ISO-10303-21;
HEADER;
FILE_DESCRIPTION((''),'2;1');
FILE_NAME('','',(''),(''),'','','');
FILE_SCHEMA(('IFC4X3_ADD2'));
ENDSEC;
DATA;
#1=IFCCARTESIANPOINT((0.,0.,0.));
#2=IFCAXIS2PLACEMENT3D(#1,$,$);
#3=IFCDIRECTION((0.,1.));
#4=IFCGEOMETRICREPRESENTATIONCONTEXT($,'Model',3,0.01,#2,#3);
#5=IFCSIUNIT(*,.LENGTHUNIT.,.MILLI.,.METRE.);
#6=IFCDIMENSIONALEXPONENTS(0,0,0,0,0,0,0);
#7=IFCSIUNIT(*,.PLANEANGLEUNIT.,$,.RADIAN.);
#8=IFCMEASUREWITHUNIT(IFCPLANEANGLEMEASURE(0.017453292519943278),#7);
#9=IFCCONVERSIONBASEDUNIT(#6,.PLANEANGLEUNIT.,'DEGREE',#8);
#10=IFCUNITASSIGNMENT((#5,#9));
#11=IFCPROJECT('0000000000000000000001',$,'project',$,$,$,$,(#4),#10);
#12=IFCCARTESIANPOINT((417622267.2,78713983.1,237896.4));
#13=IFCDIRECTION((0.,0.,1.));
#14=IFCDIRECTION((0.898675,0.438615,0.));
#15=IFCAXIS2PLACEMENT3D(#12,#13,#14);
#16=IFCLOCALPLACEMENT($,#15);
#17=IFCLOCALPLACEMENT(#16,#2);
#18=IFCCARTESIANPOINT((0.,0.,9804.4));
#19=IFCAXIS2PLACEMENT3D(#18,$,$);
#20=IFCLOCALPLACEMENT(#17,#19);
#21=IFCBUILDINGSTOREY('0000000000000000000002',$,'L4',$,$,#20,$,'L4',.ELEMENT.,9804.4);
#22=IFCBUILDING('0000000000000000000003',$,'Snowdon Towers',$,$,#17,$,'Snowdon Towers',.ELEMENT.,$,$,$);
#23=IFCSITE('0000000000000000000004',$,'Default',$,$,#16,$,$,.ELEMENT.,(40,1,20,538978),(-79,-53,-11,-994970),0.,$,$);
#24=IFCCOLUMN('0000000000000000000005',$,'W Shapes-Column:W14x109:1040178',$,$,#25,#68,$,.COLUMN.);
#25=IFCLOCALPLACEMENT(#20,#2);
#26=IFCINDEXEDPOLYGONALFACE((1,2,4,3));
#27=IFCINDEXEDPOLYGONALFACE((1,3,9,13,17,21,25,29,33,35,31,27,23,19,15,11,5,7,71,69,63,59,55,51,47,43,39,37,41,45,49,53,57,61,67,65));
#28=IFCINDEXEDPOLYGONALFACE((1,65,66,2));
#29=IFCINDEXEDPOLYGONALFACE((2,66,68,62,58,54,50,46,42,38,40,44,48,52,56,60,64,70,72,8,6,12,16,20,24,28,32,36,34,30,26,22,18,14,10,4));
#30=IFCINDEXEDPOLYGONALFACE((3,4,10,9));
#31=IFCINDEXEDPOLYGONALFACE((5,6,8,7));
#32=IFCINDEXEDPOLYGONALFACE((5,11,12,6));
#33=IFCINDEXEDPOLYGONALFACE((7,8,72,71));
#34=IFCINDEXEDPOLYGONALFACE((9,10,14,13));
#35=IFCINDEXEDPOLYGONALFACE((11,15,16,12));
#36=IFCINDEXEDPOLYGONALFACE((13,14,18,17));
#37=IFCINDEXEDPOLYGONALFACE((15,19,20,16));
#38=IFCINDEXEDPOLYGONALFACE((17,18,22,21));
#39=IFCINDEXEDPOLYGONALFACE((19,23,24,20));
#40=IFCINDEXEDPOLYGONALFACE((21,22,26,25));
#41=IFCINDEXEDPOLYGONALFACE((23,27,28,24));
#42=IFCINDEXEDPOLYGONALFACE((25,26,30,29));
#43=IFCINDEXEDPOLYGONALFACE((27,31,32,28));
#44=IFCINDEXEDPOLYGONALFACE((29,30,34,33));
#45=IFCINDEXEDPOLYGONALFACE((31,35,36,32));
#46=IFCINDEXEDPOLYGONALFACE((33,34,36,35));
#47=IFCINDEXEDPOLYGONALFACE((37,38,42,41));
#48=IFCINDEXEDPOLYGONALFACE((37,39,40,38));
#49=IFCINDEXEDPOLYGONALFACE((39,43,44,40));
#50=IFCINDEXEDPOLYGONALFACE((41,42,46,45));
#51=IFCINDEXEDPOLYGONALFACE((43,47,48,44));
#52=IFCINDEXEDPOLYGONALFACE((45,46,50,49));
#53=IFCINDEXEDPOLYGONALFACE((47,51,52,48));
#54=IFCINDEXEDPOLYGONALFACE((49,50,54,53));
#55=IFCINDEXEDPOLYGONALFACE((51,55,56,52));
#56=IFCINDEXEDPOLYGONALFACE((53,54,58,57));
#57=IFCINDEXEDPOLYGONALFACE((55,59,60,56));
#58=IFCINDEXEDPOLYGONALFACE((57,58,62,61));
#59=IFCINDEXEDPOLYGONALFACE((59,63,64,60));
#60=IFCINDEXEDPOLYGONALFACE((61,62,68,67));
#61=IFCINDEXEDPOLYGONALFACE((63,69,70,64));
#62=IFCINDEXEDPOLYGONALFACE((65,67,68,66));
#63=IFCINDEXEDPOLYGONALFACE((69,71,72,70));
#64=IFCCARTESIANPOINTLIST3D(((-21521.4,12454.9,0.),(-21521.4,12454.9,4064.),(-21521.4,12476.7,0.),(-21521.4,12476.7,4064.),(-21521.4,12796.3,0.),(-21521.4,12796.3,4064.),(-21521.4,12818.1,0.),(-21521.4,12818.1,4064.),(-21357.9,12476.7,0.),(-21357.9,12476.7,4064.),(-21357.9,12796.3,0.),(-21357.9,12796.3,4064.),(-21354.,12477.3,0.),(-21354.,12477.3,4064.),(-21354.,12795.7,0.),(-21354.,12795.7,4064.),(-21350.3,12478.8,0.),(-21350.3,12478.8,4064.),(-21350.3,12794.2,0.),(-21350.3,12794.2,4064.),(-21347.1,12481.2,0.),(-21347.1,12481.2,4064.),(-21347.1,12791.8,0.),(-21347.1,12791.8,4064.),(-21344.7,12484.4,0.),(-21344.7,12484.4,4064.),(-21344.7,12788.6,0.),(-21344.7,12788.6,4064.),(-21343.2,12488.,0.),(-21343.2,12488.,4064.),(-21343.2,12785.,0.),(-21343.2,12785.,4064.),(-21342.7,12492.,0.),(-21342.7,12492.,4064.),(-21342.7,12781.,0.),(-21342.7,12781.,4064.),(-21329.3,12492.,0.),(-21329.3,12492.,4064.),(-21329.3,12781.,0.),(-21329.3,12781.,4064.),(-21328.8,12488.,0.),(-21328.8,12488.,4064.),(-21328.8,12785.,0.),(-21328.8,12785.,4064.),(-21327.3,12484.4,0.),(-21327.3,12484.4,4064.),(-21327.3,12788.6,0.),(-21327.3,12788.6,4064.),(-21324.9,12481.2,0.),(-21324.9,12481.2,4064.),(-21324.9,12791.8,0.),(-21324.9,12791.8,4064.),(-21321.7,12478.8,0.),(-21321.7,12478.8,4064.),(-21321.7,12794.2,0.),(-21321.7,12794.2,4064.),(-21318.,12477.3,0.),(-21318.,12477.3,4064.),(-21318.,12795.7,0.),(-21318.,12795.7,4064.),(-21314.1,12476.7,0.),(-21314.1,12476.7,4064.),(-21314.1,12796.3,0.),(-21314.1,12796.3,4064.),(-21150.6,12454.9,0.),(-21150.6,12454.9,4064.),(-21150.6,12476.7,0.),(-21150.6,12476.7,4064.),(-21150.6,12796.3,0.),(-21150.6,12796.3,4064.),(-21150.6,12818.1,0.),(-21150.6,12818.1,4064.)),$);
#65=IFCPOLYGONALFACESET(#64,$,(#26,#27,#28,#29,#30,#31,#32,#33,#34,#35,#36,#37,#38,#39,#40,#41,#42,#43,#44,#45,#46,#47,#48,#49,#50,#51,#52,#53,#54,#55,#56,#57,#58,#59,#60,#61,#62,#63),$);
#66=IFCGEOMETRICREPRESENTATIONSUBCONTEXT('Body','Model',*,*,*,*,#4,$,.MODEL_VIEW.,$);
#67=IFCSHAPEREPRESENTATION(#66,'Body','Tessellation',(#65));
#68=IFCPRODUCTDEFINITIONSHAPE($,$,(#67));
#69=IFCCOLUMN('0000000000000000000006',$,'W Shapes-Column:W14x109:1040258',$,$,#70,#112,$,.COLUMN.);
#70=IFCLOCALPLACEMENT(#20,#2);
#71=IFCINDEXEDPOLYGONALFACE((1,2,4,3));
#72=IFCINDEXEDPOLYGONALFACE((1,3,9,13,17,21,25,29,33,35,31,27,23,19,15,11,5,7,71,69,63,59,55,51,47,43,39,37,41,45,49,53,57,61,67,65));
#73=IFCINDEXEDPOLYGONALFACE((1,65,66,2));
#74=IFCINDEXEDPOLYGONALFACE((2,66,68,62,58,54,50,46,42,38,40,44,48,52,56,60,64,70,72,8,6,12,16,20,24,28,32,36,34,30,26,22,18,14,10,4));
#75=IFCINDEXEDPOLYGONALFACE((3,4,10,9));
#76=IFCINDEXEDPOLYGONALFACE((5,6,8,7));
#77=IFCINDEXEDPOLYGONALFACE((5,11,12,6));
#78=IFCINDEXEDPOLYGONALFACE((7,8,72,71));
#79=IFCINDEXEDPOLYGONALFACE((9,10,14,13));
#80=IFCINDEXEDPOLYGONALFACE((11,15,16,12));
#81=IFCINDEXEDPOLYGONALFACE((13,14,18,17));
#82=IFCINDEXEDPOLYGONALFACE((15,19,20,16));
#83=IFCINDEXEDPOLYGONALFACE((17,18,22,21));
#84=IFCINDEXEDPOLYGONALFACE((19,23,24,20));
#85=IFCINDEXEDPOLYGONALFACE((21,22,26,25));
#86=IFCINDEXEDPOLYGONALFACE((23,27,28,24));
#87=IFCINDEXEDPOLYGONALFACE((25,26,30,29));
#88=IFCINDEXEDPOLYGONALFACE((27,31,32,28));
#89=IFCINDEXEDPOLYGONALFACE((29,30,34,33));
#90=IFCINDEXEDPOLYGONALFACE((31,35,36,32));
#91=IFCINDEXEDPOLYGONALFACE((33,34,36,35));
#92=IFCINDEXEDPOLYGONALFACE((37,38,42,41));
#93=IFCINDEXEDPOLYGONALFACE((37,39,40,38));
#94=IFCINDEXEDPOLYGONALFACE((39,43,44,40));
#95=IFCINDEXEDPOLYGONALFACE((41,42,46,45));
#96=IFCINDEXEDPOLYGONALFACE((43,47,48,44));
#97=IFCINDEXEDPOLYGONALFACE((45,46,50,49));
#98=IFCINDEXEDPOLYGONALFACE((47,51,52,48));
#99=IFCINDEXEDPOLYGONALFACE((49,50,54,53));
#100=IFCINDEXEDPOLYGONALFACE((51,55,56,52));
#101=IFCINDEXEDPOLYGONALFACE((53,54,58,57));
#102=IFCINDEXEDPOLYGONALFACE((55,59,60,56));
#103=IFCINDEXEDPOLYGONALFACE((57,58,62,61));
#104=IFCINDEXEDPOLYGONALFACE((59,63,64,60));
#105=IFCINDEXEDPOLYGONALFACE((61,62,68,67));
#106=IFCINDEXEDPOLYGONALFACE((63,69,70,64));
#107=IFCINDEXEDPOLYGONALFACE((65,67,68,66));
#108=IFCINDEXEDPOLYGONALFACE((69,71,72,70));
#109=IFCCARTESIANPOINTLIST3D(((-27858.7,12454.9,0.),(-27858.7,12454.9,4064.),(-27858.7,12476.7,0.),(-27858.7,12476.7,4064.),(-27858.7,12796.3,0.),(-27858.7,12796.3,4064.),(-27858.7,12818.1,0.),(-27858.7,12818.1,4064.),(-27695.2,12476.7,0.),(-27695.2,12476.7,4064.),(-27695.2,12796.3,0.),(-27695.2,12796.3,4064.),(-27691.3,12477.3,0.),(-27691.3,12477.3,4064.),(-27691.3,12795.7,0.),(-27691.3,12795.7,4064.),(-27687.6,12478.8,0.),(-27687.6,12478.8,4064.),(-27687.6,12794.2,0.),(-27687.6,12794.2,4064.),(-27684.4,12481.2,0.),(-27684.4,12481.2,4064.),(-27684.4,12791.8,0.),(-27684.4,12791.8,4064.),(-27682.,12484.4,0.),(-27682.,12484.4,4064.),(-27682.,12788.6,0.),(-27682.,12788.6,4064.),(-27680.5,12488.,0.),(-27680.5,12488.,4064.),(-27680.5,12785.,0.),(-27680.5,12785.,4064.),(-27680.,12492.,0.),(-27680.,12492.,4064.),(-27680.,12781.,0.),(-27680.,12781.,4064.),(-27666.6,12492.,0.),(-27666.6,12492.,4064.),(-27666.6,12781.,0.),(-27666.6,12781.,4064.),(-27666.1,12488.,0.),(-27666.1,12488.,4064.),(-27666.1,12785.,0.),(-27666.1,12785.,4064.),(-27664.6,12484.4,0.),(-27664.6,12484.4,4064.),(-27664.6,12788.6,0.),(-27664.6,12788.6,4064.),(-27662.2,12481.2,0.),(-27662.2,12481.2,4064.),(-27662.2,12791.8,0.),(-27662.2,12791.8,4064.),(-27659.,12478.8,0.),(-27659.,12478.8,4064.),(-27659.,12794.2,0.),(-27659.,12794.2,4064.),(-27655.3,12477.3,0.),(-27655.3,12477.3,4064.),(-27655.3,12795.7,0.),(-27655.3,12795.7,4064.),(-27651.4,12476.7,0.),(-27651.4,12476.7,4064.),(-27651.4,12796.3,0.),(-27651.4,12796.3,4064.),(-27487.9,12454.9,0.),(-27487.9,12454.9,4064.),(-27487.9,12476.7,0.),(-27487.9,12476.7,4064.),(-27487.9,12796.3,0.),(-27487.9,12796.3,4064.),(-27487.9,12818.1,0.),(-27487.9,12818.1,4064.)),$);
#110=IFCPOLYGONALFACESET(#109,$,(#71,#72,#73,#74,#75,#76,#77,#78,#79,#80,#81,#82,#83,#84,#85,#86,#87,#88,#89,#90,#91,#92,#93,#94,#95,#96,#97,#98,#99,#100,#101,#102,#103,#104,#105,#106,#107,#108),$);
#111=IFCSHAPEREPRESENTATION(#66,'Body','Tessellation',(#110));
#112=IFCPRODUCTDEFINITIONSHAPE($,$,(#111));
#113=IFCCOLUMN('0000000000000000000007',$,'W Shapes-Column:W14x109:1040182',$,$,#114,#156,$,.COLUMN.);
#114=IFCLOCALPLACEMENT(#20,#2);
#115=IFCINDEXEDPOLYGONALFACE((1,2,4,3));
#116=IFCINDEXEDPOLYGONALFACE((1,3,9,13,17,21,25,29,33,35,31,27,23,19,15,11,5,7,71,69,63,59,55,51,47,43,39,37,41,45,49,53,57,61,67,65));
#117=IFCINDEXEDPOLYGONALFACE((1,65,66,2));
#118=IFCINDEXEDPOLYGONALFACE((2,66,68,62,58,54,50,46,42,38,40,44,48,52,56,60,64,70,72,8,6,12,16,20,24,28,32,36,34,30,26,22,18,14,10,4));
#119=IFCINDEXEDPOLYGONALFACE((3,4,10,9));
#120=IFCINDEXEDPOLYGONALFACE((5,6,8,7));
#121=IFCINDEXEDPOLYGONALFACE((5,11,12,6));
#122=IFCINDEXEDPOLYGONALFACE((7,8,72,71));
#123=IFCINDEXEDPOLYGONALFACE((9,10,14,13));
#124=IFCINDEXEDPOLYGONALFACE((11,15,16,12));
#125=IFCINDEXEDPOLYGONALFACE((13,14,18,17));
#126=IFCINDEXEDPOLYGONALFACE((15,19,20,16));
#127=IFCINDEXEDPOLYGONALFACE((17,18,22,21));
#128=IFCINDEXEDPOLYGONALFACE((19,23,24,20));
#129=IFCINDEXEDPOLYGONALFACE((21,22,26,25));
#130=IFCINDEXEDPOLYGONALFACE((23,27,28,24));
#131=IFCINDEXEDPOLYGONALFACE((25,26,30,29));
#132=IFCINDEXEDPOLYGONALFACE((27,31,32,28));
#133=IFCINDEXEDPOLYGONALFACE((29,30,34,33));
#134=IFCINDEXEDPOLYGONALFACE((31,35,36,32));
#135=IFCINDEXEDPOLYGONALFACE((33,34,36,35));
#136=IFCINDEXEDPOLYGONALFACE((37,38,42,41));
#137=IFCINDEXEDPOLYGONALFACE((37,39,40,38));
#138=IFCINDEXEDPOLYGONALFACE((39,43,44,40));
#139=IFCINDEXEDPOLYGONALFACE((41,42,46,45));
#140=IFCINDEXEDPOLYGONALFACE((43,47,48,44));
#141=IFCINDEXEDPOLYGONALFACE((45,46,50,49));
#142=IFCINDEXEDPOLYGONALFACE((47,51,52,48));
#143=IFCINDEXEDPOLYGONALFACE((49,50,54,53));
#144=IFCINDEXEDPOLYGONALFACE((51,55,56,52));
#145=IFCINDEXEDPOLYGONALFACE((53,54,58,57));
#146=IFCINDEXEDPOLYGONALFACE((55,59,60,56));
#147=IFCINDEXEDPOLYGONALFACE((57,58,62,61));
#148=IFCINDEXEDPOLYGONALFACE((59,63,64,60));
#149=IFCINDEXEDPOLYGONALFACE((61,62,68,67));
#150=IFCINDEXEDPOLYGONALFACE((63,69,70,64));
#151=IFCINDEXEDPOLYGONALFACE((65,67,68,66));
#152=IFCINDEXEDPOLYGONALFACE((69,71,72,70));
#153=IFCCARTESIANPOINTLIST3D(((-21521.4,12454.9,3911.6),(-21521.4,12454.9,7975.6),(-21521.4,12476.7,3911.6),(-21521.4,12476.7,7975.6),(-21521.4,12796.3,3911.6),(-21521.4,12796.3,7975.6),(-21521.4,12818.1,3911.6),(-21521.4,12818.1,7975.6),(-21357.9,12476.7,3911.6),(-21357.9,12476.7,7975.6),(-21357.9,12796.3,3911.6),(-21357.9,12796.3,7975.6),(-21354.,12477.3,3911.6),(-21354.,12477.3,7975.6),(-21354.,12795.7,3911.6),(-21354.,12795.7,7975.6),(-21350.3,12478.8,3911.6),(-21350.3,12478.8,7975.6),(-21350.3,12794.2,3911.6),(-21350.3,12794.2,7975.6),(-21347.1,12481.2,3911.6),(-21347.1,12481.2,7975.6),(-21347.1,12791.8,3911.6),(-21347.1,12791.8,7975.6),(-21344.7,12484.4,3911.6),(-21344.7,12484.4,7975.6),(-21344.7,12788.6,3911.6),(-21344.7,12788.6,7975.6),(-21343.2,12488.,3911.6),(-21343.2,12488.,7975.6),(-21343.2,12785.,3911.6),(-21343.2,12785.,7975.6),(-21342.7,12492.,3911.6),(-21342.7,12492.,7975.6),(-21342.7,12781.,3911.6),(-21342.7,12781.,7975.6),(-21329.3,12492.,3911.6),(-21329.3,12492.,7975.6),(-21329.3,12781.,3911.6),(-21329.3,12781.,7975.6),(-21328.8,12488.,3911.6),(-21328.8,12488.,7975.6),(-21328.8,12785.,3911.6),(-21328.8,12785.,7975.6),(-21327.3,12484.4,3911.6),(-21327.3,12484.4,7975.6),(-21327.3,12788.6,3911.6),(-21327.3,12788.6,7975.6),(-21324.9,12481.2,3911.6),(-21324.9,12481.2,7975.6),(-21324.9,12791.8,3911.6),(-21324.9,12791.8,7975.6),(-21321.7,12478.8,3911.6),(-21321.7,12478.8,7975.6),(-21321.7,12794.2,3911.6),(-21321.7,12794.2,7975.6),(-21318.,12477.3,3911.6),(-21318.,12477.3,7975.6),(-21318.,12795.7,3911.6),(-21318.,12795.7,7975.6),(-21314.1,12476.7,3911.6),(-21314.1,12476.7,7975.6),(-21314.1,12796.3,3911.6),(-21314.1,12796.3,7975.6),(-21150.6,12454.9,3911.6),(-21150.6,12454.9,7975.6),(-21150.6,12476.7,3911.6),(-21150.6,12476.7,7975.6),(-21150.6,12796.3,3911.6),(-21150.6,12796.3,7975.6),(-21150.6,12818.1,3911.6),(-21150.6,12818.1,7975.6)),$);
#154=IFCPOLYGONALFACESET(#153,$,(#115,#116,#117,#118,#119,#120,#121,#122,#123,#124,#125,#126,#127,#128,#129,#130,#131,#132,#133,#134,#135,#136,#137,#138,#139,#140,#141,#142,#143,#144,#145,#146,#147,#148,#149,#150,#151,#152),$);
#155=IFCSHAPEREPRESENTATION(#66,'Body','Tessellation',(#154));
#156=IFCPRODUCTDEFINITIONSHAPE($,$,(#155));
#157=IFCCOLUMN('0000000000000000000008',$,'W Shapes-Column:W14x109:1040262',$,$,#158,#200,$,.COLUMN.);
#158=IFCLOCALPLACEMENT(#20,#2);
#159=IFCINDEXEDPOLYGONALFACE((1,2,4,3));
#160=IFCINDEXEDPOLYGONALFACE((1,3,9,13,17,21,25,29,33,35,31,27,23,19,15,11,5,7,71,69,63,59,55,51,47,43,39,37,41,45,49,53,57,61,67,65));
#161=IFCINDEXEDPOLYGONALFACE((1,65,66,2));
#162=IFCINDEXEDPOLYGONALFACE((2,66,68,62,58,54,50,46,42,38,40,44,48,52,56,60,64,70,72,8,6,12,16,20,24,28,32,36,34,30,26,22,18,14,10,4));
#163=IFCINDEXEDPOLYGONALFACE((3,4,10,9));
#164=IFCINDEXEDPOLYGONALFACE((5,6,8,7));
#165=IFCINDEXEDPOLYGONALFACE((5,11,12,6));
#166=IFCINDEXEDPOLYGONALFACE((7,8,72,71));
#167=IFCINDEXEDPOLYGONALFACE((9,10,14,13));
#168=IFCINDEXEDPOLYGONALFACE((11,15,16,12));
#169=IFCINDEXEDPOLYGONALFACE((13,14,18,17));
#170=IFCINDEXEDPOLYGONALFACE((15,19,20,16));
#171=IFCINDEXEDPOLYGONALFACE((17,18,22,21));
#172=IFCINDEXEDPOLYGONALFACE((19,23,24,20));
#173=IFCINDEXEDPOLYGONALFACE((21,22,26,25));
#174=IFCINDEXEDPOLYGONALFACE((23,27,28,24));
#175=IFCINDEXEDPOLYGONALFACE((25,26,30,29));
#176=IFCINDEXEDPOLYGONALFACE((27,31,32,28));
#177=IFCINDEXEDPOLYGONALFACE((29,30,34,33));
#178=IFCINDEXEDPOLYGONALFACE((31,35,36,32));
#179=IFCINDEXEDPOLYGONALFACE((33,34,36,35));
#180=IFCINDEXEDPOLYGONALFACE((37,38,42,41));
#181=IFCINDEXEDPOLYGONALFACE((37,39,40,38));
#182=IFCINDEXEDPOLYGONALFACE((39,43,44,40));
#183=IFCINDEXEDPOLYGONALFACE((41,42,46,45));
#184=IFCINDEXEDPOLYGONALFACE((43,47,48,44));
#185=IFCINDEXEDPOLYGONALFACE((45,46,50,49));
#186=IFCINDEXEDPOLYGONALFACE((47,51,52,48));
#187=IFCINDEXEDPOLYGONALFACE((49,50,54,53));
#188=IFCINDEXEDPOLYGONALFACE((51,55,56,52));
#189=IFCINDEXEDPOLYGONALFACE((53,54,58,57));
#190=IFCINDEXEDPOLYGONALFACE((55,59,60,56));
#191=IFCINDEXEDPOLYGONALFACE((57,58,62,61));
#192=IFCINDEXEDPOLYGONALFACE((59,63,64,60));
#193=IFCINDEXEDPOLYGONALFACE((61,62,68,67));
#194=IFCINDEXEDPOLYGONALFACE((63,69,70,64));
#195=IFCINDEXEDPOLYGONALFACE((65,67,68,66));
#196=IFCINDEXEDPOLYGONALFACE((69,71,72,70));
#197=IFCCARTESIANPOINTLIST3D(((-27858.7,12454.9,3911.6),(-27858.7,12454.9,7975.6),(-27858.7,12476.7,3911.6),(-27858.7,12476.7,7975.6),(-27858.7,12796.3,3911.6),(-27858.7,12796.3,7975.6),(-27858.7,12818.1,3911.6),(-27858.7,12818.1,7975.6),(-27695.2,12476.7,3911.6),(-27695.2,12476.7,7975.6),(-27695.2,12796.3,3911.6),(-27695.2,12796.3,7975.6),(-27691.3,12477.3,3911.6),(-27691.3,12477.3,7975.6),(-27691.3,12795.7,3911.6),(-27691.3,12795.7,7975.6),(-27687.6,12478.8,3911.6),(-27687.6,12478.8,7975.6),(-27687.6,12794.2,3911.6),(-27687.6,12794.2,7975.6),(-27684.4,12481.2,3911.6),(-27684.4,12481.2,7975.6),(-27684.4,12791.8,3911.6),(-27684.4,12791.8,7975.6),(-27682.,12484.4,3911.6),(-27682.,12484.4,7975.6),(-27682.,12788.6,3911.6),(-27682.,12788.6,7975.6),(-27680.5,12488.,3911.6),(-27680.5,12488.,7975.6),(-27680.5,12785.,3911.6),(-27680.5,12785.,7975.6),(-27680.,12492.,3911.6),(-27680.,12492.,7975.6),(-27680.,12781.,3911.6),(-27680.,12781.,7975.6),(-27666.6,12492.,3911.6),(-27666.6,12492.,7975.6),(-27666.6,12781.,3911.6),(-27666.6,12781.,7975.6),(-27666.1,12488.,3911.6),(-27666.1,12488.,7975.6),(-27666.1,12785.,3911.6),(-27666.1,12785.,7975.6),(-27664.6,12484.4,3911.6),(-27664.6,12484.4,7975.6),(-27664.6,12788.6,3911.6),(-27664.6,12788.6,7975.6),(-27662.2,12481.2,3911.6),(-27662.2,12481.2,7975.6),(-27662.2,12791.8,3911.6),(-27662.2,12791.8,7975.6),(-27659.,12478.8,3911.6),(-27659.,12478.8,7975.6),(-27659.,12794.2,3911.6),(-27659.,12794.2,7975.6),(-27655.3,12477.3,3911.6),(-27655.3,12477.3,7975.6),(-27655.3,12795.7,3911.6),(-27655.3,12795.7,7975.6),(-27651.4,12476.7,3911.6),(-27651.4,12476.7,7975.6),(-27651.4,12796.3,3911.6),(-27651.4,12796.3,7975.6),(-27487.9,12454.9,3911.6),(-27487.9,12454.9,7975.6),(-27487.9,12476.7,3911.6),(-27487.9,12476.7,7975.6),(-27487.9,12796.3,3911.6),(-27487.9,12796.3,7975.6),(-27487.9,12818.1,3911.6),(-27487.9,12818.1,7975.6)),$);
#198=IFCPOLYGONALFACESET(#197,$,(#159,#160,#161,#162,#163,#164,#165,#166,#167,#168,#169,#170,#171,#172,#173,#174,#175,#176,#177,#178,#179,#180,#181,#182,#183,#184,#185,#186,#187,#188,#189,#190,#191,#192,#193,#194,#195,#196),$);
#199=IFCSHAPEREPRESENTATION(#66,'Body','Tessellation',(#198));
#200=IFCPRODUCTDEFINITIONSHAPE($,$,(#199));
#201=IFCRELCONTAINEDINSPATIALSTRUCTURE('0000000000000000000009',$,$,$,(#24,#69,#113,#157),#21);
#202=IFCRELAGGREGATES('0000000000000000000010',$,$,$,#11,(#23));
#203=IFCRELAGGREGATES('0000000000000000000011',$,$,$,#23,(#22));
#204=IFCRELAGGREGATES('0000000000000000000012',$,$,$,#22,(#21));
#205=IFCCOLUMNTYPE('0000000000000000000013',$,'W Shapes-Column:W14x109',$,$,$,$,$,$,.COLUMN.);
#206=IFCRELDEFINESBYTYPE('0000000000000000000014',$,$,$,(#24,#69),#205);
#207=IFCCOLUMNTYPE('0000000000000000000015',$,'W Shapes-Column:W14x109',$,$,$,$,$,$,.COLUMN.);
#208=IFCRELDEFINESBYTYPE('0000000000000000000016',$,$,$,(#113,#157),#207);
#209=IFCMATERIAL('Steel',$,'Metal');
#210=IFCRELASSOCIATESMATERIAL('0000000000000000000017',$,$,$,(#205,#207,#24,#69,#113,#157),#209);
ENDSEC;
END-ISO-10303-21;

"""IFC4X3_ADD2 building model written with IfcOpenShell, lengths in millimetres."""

from ifc_helpers import new_model, entity, si_unit, converted_unit, direction, frame, frame_2d, origin, place, context, subcontext, project, spatial, i_section, extrude, source, transform, mapped, material, material_profile, profile_set, profile_usage, type_object, type_shapes, element, save


model = new_model("IFC4X3_ADD2")

# Units and contexts
model_context = context("Model", 3, precision=0.01, world=origin(), true_north=direction((0.0, 1.0)))
body_context = subcontext(model_context, "Body", "Model", "MODEL_VIEW")
ifc_project = project(units=[si_unit("LENGTHUNIT", "METRE", prefix="MILLI"), converted_unit("PLANEANGLEUNIT", "DEGREE", entity("IfcPlaneAngleMeasure", 0.017453292519943278), si_unit("PLANEANGLEUNIT", "RADIAN"), dimensions=[0, 0, 0, 0, 0, 0, 0])], contexts=[model_context])

# Site, building, storey
site_placement = place(None, frame((417622267.2, 78713983.1, 237896.4), z_axis=(0.0, 0.0, 1.0), x_axis=(0.898675, 0.438615, 0.0)))
site = spatial("IfcSite", under=ifc_project, at=site_placement, Name="Default", CompositionType="ELEMENT", RefLatitude=(40, 1, 20, 538978), RefLongitude=(-79, -53, -11, -994970), RefElevation=0.0)
building_placement = place(site_placement, origin())
building = spatial("IfcBuilding", under=site, at=building_placement, Name="Snowdon Towers", LongName="Snowdon Towers", CompositionType="ELEMENT")
storey_placement = place(building_placement, frame((0.0, 0.0, 9804.4)))
storey = spatial("IfcBuildingStorey", under=building, at=storey_placement, Name="L4", LongName="L4", CompositionType="ELEMENT", Elevation=9804.4)

# Columns
ifc_material_1 = material(Name="Steel", Category="Metal")
ifc_material_profile_1 = material_profile(ifc_material_1, i_section(OverallWidth=370.8, OverallDepth=363.2, WebThickness=13.3, FlangeThickness=21.8, FilletRadius=15.2, at=frame_2d((0.0, 0.0), x_axis=(1.0, 0.0))), Name="W14x109")
ifc_profile_set_1 = profile_set([ifc_material_profile_1], Name="W14x109")
ifc_profile_usage_1 = profile_usage(ifc_profile_set_1)
column_type_1 = type_object("IfcColumnType", Name="W Shapes-Column:W14x109", PredefinedType="COLUMN", material=ifc_profile_set_1)
shared_shape_1 = source(origin(), body_context, "Body", "SweptSolid", [
    extrude(i_section(OverallWidth=370.8, OverallDepth=363.2, WebThickness=13.3, FlangeThickness=21.8, FilletRadius=15.2, at=frame_2d((0.0, 0.0), x_axis=(1.0, 0.0))), frame((0.0, 0.0, 9804.4), z_axis=(0.0, 0.0, 1.0), x_axis=(-1.0, 0.0, 0.0)), (0.0, 0.0, 1.0), 4064.0),
])
type_shapes(column_type_1, [shared_shape_1])
for number, where, z_axis, x_axis, name in (
    (1, (-21336.0, 12636.5, -9804.4), (0.0, 0.0, 1.0), (-1.0, 0.0, 0.0), "W Shapes-Column:W14x109:1040178"),
    (2, (-27673.3, 12636.5, -9804.4), (0.0, 0.0, 1.0), (-1.0, 0.0, 0.0), "W Shapes-Column:W14x109:1040258"),
):
    element("IfcColumn", number, at=place(storey_placement, frame(where, z_axis=z_axis, x_axis=x_axis)), inside=storey, type_object=column_type_1, material=ifc_profile_usage_1, Name=name, PredefinedType="COLUMN", context=body_context, shape_type="MappedRepresentation", body=[
        mapped(shared_shape_1, transform((0.0, 0.0, 0.0), scale=1.0)),
    ])
column_type_2 = type_object("IfcColumnType", Name="W Shapes-Column:W14x109", PredefinedType="COLUMN", material=ifc_profile_set_1)
shared_shape_2 = source(origin(), body_context, "Body", "SweptSolid", [
    extrude(i_section(OverallWidth=370.8, OverallDepth=363.2, WebThickness=13.3, FlangeThickness=21.8, FilletRadius=15.2, at=frame_2d((0.0, 0.0), x_axis=(1.0, 0.0))), frame((0.0, 0.0, 13716.0), z_axis=(0.0, 0.0, 1.0), x_axis=(-1.0, 0.0, 0.0)), (0.0, 0.0, 1.0), 4064.0),
])
type_shapes(column_type_2, [shared_shape_2])
for number, where, z_axis, x_axis, name in (
    (3, (-21336.0, 12636.5, -9804.4), (0.0, 0.0, 1.0), (-1.0, 0.0, 0.0), "W Shapes-Column:W14x109:1040182"),
    (4, (-27673.3, 12636.5, -9804.4), (0.0, 0.0, 1.0), (-1.0, 0.0, 0.0), "W Shapes-Column:W14x109:1040262"),
):
    element("IfcColumn", number, at=place(storey_placement, frame(where, z_axis=z_axis, x_axis=x_axis)), inside=storey, type_object=column_type_2, material=ifc_profile_usage_1, Name=name, PredefinedType="COLUMN", context=body_context, shape_type="MappedRepresentation", body=[
        mapped(shared_shape_2, transform((0.0, 0.0, 0.0), scale=1.0)),
    ])

save(model, "model.ifc")
